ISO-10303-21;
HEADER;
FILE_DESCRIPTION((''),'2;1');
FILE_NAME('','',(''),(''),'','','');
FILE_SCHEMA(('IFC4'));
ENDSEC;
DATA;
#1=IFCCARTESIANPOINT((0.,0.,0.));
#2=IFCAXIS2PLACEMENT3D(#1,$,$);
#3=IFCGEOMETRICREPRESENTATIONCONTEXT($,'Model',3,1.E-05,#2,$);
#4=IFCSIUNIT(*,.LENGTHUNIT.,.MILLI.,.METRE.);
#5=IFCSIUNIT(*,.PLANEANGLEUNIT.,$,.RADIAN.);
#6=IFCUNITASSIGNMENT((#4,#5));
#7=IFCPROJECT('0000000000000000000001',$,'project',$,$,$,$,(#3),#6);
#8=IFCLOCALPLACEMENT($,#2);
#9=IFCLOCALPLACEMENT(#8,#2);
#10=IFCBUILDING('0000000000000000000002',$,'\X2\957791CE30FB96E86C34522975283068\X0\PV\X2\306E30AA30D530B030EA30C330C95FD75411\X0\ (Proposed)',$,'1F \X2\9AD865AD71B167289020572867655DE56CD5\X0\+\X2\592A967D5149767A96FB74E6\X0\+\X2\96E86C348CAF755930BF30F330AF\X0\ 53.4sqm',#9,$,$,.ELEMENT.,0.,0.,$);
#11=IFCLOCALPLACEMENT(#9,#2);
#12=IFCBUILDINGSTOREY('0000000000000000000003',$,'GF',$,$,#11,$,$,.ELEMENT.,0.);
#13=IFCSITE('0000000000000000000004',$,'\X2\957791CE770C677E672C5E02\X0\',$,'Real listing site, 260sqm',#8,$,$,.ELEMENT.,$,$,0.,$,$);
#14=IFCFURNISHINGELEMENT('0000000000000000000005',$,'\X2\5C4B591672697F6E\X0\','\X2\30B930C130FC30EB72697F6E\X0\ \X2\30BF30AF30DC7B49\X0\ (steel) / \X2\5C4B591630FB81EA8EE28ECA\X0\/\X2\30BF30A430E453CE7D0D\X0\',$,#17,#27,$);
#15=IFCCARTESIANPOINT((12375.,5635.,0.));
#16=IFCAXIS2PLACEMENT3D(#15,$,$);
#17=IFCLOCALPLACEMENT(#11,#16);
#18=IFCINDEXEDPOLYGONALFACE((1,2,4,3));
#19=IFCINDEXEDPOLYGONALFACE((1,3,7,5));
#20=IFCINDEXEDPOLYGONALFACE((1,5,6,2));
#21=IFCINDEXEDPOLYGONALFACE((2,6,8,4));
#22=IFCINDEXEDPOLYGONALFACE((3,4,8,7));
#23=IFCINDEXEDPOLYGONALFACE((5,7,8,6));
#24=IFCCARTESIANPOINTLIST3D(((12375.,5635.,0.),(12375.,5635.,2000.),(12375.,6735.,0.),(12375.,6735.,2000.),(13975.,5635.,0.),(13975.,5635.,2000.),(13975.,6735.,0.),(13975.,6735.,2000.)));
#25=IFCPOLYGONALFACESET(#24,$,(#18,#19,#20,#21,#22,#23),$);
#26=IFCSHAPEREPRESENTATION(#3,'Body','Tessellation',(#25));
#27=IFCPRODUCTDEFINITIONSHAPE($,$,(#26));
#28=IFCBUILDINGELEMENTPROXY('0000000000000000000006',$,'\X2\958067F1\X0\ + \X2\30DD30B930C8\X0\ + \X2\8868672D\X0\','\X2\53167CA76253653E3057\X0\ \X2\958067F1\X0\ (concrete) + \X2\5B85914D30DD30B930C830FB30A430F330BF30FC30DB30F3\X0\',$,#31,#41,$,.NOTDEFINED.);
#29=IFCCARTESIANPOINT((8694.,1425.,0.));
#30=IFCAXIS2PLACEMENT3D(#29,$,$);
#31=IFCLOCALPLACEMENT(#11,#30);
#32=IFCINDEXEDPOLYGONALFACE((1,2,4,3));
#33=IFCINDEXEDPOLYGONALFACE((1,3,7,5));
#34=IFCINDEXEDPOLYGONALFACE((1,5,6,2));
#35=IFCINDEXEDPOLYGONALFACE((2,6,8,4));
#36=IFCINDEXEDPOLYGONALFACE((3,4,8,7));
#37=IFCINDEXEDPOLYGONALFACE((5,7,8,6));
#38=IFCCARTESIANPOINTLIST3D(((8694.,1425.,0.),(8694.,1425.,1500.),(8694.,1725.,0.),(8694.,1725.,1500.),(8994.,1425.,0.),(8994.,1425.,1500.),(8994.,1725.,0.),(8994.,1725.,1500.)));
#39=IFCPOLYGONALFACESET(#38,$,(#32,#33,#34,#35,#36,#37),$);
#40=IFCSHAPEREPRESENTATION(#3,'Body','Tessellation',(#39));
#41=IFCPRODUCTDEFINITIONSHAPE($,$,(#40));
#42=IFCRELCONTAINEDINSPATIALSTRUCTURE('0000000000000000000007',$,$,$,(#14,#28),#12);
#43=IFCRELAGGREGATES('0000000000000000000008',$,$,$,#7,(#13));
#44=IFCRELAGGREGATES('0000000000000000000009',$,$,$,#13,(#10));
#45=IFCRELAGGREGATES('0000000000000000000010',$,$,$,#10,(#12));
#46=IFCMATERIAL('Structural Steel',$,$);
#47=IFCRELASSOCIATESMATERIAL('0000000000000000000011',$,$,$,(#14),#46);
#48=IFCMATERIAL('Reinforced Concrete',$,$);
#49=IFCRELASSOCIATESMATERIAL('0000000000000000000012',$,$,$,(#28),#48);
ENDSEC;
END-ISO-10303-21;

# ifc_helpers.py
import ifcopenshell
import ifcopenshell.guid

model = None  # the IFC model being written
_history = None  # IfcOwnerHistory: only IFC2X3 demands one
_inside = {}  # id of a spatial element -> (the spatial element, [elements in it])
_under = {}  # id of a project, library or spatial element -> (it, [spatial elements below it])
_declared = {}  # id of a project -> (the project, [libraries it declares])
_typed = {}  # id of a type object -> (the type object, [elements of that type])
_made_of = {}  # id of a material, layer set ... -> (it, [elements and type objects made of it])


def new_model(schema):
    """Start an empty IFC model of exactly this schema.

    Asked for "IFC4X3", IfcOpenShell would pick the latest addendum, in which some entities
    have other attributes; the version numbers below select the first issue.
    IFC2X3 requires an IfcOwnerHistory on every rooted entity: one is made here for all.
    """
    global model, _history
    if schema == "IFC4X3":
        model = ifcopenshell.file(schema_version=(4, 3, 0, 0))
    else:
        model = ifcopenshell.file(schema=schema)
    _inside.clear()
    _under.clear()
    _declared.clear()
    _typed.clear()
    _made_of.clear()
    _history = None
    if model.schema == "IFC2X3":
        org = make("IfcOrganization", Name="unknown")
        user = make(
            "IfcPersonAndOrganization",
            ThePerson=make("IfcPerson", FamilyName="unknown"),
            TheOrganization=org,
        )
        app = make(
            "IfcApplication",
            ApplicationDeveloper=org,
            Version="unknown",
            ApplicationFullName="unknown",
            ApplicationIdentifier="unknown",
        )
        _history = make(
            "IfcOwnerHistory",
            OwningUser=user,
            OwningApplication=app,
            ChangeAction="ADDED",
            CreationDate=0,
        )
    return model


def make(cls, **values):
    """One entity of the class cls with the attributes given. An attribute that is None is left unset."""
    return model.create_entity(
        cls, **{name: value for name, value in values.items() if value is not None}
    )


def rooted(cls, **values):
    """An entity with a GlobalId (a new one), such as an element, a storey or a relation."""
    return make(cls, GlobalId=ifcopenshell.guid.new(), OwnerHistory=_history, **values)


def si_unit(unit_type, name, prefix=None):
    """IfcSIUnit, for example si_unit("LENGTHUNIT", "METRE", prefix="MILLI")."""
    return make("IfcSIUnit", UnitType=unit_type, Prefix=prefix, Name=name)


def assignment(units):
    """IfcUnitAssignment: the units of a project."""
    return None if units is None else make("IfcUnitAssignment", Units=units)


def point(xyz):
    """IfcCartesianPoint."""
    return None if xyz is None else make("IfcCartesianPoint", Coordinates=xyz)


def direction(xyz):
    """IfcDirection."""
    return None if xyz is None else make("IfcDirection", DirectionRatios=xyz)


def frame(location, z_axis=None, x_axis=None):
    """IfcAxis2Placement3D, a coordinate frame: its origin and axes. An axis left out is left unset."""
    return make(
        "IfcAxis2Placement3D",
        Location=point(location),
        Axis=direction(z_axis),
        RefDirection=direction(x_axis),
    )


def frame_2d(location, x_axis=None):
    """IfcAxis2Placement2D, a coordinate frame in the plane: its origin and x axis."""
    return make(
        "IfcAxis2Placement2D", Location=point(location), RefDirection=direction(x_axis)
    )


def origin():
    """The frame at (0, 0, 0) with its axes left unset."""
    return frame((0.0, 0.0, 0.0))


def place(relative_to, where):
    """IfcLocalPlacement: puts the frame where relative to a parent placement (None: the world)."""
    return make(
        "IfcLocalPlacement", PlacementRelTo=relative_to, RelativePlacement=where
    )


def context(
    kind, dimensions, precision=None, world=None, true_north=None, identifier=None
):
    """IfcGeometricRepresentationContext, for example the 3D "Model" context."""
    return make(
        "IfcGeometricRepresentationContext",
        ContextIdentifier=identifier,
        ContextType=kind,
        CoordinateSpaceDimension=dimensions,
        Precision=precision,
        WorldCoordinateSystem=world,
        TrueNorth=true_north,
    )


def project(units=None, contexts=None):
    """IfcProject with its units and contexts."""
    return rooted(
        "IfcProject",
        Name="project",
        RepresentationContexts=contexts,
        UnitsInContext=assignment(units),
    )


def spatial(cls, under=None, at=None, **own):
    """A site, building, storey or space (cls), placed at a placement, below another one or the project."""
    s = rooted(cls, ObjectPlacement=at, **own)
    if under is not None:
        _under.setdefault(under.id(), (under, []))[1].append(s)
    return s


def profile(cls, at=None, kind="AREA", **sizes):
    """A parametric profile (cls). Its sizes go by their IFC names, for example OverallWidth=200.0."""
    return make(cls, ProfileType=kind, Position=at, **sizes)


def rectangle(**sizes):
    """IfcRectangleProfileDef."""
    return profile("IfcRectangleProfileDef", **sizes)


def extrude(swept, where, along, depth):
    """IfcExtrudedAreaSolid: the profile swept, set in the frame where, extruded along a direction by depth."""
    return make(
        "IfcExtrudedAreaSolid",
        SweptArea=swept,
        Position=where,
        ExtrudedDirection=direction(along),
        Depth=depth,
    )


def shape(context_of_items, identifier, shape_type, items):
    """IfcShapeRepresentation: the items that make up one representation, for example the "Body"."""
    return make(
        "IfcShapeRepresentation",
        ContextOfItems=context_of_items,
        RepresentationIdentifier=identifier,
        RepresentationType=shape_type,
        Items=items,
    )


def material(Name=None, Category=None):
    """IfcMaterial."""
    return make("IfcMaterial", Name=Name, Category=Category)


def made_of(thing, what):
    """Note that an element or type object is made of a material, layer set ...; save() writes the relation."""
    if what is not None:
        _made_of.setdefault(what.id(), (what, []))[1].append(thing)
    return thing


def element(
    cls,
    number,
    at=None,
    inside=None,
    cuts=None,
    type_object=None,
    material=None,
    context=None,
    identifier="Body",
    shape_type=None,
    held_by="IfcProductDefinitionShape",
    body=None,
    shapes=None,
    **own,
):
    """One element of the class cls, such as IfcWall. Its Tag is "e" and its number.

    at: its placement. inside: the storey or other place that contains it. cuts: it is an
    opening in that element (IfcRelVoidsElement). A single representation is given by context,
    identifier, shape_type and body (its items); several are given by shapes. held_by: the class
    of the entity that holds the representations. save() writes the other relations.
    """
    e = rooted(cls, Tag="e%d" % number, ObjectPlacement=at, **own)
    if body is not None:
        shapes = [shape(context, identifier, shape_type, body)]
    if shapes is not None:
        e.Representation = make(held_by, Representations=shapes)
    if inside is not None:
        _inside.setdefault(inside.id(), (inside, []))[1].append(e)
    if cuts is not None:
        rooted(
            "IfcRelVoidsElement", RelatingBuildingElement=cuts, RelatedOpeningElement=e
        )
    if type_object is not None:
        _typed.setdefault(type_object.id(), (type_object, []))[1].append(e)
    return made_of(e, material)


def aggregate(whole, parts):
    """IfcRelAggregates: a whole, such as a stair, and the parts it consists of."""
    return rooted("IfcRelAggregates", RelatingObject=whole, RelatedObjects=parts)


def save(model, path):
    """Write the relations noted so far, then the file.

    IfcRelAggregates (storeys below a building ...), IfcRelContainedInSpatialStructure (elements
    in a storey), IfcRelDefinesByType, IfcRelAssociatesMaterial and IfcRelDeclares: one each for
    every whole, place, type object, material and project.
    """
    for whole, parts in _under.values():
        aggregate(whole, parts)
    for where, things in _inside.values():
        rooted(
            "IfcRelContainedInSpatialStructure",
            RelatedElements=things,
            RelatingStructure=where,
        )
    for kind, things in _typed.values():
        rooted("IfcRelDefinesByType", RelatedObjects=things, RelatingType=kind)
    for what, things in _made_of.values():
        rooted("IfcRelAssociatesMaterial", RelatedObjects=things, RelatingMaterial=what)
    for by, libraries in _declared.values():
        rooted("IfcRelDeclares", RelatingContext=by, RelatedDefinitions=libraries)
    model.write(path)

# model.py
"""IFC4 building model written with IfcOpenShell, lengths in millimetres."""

from ifc_helpers import new_model, si_unit, frame, frame_2d, origin, place, context, project, spatial, rectangle, extrude, material, element, save


model = new_model("IFC4")

# Units and contexts
model_context = context("Model", 3, precision=1e-05, world=origin())
ifc_project = project(units=[si_unit("LENGTHUNIT", "METRE", prefix="MILLI"), si_unit("PLANEANGLEUNIT", "RADIAN")], contexts=[model_context])

# Site, building, storey
site_placement = place(None, origin())
site = spatial("IfcSite", under=ifc_project, at=site_placement, Name="長野県松本市", ObjectType="Real listing site, 260sqm", CompositionType="ELEMENT", RefElevation=0.0)
building_placement = place(site_placement, origin())
building = spatial("IfcBuilding", under=site, at=building_placement, Name="長野・雨水利用とPVのオフグリッド志向 (Proposed)", ObjectType="1F 高断熱木造在来工法+太陽光発電瓦+雨水貯留タンク 53.4sqm", CompositionType="ELEMENT", ElevationOfRefHeight=0.0, ElevationOfTerrain=0.0)
storey_placement = place(building_placement, origin())
storey = spatial("IfcBuildingStorey", under=building, at=storey_placement, Name="GF", CompositionType="ELEMENT", Elevation=0.0)

# Shared definitions
ifc_material_1 = material(Name="Reinforced Concrete")

# Shared definitions
ifc_material_2 = material(Name="Structural Steel")

# Furnishing element
furnishing_1_placement = place(storey_placement, frame((12375.0, 5635.0, 0.0)))
element("IfcFurnishingElement", 1, at=furnishing_1_placement, inside=storey, material=ifc_material_2, Name="屋外物置", Description="スチール物置 タクボ等 (steel) / 屋外・自転車/タイヤ収納", context=model_context, shape_type="SweptSolid", body=[
    extrude(rectangle(XDim=1600.0, YDim=1100.0, at=frame_2d((800.0, 550.0))), frame((12375.0, 5635.0, 0.0)), (0.0, 0.0, 1.0), 2000.0),
])

# Building element proxy
proxy_placement = place(storey_placement, frame((8694.0, 1425.0, 0.0)))
element("IfcBuildingElementProxy", 2, at=proxy_placement, inside=storey, material=ifc_material_1, Name="門柱 + ポスト + 表札", Description="化粧打放し 門柱 (concrete) + 宅配ポスト・インターホン", PredefinedType="NOTDEFINED", context=model_context, shape_type="SweptSolid", body=[
    extrude(rectangle(XDim=300.0, YDim=300.0, at=frame_2d((150.0, 150.0))), frame((8694.0, 1425.0, 0.0)), (0.0, 0.0, 1.0), 1500.0),
])

save(model, "model.ifc")
